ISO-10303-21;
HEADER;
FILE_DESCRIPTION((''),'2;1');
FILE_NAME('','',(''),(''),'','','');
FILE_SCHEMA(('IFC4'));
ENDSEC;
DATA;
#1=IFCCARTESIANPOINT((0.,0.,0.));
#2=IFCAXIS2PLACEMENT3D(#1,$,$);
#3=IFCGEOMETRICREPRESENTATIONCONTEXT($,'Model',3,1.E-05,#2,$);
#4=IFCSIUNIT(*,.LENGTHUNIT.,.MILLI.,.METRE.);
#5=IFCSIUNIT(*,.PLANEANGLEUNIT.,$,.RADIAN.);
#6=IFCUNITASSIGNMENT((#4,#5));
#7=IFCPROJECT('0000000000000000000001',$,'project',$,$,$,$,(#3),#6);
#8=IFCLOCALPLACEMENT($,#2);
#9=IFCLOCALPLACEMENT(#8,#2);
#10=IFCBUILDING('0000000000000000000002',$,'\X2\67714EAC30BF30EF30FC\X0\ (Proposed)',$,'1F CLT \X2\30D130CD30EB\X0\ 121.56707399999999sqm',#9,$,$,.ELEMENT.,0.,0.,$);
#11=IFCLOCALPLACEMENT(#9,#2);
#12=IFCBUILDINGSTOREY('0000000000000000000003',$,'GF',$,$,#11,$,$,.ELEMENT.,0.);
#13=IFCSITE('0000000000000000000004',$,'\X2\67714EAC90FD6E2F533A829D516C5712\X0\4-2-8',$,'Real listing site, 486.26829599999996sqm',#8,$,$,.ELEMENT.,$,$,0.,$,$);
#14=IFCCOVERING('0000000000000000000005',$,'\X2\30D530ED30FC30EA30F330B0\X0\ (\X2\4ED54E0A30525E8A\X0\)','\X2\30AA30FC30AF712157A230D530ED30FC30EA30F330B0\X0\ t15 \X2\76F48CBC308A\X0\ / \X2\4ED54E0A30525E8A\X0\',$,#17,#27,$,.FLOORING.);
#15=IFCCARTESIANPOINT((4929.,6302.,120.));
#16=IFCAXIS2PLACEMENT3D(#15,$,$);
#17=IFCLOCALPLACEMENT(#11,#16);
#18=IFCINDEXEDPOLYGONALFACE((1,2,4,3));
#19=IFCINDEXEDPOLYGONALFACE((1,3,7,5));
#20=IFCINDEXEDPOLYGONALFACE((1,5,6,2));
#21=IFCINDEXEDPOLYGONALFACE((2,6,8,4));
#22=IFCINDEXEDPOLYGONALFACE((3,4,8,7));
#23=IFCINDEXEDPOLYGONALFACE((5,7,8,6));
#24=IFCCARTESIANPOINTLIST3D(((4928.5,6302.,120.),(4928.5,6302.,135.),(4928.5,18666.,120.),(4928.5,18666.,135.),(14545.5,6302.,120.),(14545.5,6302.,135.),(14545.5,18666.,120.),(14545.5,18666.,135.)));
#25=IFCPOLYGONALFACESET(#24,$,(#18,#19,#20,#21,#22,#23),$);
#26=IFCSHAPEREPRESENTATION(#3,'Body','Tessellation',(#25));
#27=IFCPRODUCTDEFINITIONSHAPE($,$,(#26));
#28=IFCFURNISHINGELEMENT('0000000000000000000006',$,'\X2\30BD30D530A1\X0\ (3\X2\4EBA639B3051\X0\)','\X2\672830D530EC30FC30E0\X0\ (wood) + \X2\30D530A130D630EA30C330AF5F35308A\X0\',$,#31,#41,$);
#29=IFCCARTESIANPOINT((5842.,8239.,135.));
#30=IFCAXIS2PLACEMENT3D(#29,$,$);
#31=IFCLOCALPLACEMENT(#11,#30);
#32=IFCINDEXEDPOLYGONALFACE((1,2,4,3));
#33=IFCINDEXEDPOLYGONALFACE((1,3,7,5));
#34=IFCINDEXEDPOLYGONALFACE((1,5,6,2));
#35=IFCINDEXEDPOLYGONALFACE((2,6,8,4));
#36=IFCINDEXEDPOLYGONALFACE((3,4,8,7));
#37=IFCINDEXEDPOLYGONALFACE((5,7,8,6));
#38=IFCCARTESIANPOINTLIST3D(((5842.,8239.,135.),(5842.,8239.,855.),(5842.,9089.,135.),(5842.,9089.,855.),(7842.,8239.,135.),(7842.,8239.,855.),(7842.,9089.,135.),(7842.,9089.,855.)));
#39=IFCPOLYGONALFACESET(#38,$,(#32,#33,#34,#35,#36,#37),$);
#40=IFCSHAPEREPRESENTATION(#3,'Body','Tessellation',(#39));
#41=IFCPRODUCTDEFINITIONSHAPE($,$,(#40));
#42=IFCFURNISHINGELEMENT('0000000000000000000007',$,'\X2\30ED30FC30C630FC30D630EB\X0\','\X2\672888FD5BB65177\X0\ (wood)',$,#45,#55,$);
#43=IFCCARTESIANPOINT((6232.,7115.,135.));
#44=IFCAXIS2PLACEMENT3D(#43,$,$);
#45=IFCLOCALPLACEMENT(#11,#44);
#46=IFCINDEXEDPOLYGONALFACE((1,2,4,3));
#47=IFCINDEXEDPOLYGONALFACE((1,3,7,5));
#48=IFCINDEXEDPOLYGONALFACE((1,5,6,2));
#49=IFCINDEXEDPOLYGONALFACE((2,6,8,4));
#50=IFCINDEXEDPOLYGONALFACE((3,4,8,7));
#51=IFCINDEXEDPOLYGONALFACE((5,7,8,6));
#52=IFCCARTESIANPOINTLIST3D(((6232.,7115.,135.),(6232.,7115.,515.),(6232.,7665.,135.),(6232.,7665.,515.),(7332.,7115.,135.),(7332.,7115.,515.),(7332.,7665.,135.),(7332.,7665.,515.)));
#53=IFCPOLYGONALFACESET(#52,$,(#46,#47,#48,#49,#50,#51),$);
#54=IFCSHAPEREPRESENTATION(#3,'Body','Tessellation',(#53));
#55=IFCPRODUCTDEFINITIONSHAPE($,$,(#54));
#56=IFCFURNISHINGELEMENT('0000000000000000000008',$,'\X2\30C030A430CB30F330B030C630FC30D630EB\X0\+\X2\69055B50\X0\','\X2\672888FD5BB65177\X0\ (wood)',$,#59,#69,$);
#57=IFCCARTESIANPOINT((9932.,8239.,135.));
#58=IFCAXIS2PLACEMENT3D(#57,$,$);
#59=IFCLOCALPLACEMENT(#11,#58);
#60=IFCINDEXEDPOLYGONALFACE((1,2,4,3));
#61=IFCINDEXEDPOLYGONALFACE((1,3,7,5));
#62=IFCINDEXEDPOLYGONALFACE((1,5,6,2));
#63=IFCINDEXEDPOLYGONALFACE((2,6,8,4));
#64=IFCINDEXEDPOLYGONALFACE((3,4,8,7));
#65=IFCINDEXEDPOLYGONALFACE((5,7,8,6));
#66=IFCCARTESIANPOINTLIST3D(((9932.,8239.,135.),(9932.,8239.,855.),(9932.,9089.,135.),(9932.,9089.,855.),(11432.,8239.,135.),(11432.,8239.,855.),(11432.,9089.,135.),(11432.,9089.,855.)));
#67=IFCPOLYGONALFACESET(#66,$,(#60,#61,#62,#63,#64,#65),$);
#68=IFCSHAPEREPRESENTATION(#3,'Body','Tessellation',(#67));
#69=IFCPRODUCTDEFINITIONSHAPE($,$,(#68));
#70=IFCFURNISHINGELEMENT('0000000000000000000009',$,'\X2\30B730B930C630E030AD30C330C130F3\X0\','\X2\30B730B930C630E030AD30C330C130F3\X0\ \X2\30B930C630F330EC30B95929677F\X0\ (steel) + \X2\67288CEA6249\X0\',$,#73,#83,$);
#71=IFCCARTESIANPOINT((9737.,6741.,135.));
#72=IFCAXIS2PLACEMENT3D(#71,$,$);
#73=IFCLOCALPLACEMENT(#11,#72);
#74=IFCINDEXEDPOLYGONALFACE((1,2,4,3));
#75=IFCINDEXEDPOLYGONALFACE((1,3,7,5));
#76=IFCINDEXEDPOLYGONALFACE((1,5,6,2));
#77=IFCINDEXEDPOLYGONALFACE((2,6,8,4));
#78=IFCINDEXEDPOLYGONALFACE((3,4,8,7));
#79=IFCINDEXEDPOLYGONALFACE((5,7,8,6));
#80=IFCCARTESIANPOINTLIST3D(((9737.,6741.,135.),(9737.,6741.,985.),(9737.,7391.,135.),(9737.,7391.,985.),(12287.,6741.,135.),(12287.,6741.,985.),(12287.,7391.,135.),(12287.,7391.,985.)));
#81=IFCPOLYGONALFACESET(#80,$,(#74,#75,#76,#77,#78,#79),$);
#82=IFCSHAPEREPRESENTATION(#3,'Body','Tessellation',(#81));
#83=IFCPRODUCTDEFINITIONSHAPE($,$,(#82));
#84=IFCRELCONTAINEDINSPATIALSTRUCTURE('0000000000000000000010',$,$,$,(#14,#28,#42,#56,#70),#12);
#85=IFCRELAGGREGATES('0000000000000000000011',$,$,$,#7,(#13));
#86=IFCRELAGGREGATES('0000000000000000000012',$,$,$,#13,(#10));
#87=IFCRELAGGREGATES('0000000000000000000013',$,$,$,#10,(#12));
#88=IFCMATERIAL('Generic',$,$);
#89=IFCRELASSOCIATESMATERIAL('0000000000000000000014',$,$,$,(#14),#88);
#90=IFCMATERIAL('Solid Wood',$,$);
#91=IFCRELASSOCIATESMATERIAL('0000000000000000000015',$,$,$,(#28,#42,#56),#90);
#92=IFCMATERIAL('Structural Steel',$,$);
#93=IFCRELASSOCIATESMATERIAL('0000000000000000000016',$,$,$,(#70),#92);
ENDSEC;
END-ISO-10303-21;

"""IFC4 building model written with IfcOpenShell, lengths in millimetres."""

from ifc_helpers import new_model, si_unit, frame, frame_2d, origin, place, context, project, spatial, rectangle, extrude, material, element, save


model = new_model("IFC4")

# Units and contexts
model_context = context("Model", 3, precision=1e-05, world=origin())
ifc_project = project(units=[si_unit("LENGTHUNIT", "METRE", prefix="MILLI"), si_unit("PLANEANGLEUNIT", "RADIAN")], contexts=[model_context])

# Site, building, storey
site_placement = place(None, origin())
site = spatial("IfcSite", under=ifc_project, at=site_placement, Name="東京都港区芝公園4-2-8", ObjectType="Real listing site, 486.26829599999996sqm", CompositionType="ELEMENT", RefElevation=0.0)
building_placement = place(site_placement, origin())
building = spatial("IfcBuilding", under=site, at=building_placement, Name="東京タワー (Proposed)", ObjectType="1F CLT パネル 121.56707399999999sqm", CompositionType="ELEMENT", ElevationOfRefHeight=0.0, ElevationOfTerrain=0.0)
storey_placement = place(building_placement, origin())
storey = spatial("IfcBuildingStorey", under=building, at=storey_placement, Name="GF", CompositionType="ELEMENT", Elevation=0.0)

# Shared definitions
ifc_material_1 = material(Name="Solid Wood")

# Shared definitions
ifc_material_2 = material(Name="Structural Steel")

# Covering
ifc_material_3 = material(Name="Generic")
covering_placement = place(storey_placement, frame((4929.0, 6302.0, 120.0)))
element("IfcCovering", 1, at=covering_placement, inside=storey, material=ifc_material_3, Name="フローリング (仕上げ床)", Description="オーク無垢フローリング t15 直貼り / 仕上げ床", PredefinedType="FLOORING", context=model_context, shape_type="SweptSolid", body=[
    extrude(rectangle(XDim=9617.0, YDim=12364.0, at=frame_2d((4808.0, 6182.0))), frame((4929.0, 6302.0, 120.0)), (0.0, 0.0, 1.0), 15.0),
])

# Furnishing elements
furnishing_1_placement = place(storey_placement, frame((5842.0, 8239.0, 135.0)))
element("IfcFurnishingElement", 2, at=furnishing_1_placement, inside=storey, material=ifc_material_1, Name="ソファ (3人掛け)", Description="木フレーム (wood) + ファブリック張り", context=model_context, shape_type="SweptSolid", body=[
    extrude(rectangle(XDim=2000.0, YDim=850.0, at=frame_2d((1000.0, 425.0))), frame((5842.0, 8239.0, 135.0)), (0.0, 0.0, 1.0), 720.0),
])
furnishing_2_placement = place(storey_placement, frame((6232.0, 7115.0, 135.0)))
element("IfcFurnishingElement", 3, at=furnishing_2_placement, inside=storey, material=ifc_material_1, Name="ローテーブル", Description="木製家具 (wood)", context=model_context, shape_type="SweptSolid", body=[
    extrude(rectangle(XDim=1100.0, YDim=550.0, at=frame_2d((550.0, 275.0))), frame((6232.0, 7115.0, 135.0)), (0.0, 0.0, 1.0), 380.0),
])
furnishing_3_placement = place(storey_placement, frame((9932.0, 8239.0, 135.0)))
element("IfcFurnishingElement", 4, at=furnishing_3_placement, inside=storey, material=ifc_material_1, Name="ダイニングテーブル+椅子", Description="木製家具 (wood)", context=model_context, shape_type="SweptSolid", body=[
    extrude(rectangle(XDim=1500.0, YDim=850.0, at=frame_2d((750.0, 425.0))), frame((9932.0, 8239.0, 135.0)), (0.0, 0.0, 1.0), 720.0),
])
furnishing_4_placement = place(storey_placement, frame((9737.0, 6741.0, 135.0)))
element("IfcFurnishingElement", 5, at=furnishing_4_placement, inside=storey, material=ifc_material_2, Name="システムキッチン", Description="システムキッチン ステンレス天板 (steel) + 木質扉", context=model_context, shape_type="SweptSolid", body=[
    extrude(rectangle(XDim=2550.0, YDim=650.0, at=frame_2d((1275.0, 325.0))), frame((9737.0, 6741.0, 135.0)), (0.0, 0.0, 1.0), 850.0),
])

save(model, "model.ifc")
